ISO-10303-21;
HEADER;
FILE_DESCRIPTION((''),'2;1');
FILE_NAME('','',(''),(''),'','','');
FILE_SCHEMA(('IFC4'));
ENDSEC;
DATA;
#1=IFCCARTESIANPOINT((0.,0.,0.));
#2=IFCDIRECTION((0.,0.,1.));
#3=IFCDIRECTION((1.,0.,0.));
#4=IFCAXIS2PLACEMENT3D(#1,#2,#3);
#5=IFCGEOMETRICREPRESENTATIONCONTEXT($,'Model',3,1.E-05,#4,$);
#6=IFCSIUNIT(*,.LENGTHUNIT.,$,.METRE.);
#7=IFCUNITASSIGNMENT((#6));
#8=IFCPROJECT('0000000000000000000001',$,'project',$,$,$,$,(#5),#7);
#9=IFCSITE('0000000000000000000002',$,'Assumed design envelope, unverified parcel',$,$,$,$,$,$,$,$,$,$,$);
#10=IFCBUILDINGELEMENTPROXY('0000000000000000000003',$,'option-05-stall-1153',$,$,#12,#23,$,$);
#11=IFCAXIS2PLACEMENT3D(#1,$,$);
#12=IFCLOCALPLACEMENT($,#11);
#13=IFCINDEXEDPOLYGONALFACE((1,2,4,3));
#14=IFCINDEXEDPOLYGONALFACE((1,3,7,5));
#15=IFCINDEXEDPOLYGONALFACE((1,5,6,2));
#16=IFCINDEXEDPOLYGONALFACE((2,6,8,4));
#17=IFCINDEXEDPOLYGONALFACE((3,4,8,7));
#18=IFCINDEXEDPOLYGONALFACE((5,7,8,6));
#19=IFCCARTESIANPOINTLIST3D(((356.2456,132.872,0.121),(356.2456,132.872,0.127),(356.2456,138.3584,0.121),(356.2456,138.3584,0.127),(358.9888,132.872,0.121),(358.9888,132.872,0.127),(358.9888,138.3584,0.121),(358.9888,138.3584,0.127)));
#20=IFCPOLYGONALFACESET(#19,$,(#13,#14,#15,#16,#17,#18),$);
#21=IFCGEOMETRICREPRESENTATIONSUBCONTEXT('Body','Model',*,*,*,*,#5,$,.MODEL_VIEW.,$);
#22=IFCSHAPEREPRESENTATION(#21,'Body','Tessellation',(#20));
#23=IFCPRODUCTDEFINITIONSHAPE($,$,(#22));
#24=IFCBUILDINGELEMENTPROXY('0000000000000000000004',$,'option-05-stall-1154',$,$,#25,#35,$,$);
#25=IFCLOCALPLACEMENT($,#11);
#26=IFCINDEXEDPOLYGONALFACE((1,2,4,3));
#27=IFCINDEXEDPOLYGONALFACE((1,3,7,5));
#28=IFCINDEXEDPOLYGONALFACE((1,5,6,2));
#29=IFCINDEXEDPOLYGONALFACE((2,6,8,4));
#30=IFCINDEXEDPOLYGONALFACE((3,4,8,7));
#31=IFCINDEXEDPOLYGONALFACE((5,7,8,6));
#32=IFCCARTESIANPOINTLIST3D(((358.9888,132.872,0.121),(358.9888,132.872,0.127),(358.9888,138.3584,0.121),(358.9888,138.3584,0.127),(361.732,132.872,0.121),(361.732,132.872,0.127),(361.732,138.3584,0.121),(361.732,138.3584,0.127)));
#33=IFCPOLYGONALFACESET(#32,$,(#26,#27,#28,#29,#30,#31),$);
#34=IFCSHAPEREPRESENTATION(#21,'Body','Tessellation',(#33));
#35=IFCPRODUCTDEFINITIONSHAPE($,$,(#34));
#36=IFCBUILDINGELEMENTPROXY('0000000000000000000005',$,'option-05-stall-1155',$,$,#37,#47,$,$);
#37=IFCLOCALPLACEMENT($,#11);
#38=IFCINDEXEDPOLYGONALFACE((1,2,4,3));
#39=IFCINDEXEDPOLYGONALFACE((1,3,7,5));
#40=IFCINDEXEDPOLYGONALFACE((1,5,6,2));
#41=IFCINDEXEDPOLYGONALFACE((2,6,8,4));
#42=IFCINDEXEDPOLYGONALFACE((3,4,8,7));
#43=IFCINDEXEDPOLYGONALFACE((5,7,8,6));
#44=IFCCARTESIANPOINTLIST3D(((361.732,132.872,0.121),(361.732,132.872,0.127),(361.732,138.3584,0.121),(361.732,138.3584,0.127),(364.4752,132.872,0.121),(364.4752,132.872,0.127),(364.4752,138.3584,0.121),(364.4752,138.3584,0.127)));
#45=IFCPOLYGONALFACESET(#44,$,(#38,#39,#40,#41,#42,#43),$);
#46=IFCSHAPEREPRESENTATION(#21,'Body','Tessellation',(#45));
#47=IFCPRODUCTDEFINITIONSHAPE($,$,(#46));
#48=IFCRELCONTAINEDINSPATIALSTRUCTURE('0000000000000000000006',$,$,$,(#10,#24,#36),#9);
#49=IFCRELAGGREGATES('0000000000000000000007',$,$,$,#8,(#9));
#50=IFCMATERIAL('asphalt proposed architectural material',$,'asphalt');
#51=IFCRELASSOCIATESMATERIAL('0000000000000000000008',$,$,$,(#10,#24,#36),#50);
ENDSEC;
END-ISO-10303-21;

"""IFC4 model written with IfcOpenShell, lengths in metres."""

from ifc_helpers import new_model, si_unit, frame, origin_with_axes, place, context, subcontext, project, spatial, rectangle, extrude, material, element, save


model = new_model("IFC4")

# Units and contexts
model_context = context("Model", 3, precision=1e-05, world=origin_with_axes())
body_context = subcontext(model_context, "Body", "Model", "MODEL_VIEW")
ifc_project = project(units=[si_unit("LENGTHUNIT", "METRE")], contexts=[model_context])

# Site
site = spatial("IfcSite", under=ifc_project, Name="Assumed design envelope, unverified parcel")

# Building element proxies
ifc_material = material(Name="asphalt proposed architectural material", Category="asphalt")
for number, where, z_axis, x_axis, name in (
    (1, (357.6172, 135.6152, 0.121), (0.0, 0.0, 1.0), (1.0, 0.0, 0.0), "option-05-stall-1153"),
    (2, (360.3604, 135.6152, 0.121), (0.0, 0.0, 1.0), (1.0, 0.0, 0.0), "option-05-stall-1154"),
    (3, (363.1036, 135.6152, 0.121), (0.0, 0.0, 1.0), (1.0, 0.0, 0.0), "option-05-stall-1155"),
):
    element("IfcBuildingElementProxy", number, at=place(None, frame(where, z_axis=z_axis, x_axis=x_axis)), inside=site, material=ifc_material, Name=name, context=body_context, shape_type="SweptSolid", body=[
        extrude(rectangle(XDim=2.7432, YDim=5.4864), origin_with_axes(), (0.0, 0.0, 1.0), 0.006),
    ])

save(model, "model.ifc")
